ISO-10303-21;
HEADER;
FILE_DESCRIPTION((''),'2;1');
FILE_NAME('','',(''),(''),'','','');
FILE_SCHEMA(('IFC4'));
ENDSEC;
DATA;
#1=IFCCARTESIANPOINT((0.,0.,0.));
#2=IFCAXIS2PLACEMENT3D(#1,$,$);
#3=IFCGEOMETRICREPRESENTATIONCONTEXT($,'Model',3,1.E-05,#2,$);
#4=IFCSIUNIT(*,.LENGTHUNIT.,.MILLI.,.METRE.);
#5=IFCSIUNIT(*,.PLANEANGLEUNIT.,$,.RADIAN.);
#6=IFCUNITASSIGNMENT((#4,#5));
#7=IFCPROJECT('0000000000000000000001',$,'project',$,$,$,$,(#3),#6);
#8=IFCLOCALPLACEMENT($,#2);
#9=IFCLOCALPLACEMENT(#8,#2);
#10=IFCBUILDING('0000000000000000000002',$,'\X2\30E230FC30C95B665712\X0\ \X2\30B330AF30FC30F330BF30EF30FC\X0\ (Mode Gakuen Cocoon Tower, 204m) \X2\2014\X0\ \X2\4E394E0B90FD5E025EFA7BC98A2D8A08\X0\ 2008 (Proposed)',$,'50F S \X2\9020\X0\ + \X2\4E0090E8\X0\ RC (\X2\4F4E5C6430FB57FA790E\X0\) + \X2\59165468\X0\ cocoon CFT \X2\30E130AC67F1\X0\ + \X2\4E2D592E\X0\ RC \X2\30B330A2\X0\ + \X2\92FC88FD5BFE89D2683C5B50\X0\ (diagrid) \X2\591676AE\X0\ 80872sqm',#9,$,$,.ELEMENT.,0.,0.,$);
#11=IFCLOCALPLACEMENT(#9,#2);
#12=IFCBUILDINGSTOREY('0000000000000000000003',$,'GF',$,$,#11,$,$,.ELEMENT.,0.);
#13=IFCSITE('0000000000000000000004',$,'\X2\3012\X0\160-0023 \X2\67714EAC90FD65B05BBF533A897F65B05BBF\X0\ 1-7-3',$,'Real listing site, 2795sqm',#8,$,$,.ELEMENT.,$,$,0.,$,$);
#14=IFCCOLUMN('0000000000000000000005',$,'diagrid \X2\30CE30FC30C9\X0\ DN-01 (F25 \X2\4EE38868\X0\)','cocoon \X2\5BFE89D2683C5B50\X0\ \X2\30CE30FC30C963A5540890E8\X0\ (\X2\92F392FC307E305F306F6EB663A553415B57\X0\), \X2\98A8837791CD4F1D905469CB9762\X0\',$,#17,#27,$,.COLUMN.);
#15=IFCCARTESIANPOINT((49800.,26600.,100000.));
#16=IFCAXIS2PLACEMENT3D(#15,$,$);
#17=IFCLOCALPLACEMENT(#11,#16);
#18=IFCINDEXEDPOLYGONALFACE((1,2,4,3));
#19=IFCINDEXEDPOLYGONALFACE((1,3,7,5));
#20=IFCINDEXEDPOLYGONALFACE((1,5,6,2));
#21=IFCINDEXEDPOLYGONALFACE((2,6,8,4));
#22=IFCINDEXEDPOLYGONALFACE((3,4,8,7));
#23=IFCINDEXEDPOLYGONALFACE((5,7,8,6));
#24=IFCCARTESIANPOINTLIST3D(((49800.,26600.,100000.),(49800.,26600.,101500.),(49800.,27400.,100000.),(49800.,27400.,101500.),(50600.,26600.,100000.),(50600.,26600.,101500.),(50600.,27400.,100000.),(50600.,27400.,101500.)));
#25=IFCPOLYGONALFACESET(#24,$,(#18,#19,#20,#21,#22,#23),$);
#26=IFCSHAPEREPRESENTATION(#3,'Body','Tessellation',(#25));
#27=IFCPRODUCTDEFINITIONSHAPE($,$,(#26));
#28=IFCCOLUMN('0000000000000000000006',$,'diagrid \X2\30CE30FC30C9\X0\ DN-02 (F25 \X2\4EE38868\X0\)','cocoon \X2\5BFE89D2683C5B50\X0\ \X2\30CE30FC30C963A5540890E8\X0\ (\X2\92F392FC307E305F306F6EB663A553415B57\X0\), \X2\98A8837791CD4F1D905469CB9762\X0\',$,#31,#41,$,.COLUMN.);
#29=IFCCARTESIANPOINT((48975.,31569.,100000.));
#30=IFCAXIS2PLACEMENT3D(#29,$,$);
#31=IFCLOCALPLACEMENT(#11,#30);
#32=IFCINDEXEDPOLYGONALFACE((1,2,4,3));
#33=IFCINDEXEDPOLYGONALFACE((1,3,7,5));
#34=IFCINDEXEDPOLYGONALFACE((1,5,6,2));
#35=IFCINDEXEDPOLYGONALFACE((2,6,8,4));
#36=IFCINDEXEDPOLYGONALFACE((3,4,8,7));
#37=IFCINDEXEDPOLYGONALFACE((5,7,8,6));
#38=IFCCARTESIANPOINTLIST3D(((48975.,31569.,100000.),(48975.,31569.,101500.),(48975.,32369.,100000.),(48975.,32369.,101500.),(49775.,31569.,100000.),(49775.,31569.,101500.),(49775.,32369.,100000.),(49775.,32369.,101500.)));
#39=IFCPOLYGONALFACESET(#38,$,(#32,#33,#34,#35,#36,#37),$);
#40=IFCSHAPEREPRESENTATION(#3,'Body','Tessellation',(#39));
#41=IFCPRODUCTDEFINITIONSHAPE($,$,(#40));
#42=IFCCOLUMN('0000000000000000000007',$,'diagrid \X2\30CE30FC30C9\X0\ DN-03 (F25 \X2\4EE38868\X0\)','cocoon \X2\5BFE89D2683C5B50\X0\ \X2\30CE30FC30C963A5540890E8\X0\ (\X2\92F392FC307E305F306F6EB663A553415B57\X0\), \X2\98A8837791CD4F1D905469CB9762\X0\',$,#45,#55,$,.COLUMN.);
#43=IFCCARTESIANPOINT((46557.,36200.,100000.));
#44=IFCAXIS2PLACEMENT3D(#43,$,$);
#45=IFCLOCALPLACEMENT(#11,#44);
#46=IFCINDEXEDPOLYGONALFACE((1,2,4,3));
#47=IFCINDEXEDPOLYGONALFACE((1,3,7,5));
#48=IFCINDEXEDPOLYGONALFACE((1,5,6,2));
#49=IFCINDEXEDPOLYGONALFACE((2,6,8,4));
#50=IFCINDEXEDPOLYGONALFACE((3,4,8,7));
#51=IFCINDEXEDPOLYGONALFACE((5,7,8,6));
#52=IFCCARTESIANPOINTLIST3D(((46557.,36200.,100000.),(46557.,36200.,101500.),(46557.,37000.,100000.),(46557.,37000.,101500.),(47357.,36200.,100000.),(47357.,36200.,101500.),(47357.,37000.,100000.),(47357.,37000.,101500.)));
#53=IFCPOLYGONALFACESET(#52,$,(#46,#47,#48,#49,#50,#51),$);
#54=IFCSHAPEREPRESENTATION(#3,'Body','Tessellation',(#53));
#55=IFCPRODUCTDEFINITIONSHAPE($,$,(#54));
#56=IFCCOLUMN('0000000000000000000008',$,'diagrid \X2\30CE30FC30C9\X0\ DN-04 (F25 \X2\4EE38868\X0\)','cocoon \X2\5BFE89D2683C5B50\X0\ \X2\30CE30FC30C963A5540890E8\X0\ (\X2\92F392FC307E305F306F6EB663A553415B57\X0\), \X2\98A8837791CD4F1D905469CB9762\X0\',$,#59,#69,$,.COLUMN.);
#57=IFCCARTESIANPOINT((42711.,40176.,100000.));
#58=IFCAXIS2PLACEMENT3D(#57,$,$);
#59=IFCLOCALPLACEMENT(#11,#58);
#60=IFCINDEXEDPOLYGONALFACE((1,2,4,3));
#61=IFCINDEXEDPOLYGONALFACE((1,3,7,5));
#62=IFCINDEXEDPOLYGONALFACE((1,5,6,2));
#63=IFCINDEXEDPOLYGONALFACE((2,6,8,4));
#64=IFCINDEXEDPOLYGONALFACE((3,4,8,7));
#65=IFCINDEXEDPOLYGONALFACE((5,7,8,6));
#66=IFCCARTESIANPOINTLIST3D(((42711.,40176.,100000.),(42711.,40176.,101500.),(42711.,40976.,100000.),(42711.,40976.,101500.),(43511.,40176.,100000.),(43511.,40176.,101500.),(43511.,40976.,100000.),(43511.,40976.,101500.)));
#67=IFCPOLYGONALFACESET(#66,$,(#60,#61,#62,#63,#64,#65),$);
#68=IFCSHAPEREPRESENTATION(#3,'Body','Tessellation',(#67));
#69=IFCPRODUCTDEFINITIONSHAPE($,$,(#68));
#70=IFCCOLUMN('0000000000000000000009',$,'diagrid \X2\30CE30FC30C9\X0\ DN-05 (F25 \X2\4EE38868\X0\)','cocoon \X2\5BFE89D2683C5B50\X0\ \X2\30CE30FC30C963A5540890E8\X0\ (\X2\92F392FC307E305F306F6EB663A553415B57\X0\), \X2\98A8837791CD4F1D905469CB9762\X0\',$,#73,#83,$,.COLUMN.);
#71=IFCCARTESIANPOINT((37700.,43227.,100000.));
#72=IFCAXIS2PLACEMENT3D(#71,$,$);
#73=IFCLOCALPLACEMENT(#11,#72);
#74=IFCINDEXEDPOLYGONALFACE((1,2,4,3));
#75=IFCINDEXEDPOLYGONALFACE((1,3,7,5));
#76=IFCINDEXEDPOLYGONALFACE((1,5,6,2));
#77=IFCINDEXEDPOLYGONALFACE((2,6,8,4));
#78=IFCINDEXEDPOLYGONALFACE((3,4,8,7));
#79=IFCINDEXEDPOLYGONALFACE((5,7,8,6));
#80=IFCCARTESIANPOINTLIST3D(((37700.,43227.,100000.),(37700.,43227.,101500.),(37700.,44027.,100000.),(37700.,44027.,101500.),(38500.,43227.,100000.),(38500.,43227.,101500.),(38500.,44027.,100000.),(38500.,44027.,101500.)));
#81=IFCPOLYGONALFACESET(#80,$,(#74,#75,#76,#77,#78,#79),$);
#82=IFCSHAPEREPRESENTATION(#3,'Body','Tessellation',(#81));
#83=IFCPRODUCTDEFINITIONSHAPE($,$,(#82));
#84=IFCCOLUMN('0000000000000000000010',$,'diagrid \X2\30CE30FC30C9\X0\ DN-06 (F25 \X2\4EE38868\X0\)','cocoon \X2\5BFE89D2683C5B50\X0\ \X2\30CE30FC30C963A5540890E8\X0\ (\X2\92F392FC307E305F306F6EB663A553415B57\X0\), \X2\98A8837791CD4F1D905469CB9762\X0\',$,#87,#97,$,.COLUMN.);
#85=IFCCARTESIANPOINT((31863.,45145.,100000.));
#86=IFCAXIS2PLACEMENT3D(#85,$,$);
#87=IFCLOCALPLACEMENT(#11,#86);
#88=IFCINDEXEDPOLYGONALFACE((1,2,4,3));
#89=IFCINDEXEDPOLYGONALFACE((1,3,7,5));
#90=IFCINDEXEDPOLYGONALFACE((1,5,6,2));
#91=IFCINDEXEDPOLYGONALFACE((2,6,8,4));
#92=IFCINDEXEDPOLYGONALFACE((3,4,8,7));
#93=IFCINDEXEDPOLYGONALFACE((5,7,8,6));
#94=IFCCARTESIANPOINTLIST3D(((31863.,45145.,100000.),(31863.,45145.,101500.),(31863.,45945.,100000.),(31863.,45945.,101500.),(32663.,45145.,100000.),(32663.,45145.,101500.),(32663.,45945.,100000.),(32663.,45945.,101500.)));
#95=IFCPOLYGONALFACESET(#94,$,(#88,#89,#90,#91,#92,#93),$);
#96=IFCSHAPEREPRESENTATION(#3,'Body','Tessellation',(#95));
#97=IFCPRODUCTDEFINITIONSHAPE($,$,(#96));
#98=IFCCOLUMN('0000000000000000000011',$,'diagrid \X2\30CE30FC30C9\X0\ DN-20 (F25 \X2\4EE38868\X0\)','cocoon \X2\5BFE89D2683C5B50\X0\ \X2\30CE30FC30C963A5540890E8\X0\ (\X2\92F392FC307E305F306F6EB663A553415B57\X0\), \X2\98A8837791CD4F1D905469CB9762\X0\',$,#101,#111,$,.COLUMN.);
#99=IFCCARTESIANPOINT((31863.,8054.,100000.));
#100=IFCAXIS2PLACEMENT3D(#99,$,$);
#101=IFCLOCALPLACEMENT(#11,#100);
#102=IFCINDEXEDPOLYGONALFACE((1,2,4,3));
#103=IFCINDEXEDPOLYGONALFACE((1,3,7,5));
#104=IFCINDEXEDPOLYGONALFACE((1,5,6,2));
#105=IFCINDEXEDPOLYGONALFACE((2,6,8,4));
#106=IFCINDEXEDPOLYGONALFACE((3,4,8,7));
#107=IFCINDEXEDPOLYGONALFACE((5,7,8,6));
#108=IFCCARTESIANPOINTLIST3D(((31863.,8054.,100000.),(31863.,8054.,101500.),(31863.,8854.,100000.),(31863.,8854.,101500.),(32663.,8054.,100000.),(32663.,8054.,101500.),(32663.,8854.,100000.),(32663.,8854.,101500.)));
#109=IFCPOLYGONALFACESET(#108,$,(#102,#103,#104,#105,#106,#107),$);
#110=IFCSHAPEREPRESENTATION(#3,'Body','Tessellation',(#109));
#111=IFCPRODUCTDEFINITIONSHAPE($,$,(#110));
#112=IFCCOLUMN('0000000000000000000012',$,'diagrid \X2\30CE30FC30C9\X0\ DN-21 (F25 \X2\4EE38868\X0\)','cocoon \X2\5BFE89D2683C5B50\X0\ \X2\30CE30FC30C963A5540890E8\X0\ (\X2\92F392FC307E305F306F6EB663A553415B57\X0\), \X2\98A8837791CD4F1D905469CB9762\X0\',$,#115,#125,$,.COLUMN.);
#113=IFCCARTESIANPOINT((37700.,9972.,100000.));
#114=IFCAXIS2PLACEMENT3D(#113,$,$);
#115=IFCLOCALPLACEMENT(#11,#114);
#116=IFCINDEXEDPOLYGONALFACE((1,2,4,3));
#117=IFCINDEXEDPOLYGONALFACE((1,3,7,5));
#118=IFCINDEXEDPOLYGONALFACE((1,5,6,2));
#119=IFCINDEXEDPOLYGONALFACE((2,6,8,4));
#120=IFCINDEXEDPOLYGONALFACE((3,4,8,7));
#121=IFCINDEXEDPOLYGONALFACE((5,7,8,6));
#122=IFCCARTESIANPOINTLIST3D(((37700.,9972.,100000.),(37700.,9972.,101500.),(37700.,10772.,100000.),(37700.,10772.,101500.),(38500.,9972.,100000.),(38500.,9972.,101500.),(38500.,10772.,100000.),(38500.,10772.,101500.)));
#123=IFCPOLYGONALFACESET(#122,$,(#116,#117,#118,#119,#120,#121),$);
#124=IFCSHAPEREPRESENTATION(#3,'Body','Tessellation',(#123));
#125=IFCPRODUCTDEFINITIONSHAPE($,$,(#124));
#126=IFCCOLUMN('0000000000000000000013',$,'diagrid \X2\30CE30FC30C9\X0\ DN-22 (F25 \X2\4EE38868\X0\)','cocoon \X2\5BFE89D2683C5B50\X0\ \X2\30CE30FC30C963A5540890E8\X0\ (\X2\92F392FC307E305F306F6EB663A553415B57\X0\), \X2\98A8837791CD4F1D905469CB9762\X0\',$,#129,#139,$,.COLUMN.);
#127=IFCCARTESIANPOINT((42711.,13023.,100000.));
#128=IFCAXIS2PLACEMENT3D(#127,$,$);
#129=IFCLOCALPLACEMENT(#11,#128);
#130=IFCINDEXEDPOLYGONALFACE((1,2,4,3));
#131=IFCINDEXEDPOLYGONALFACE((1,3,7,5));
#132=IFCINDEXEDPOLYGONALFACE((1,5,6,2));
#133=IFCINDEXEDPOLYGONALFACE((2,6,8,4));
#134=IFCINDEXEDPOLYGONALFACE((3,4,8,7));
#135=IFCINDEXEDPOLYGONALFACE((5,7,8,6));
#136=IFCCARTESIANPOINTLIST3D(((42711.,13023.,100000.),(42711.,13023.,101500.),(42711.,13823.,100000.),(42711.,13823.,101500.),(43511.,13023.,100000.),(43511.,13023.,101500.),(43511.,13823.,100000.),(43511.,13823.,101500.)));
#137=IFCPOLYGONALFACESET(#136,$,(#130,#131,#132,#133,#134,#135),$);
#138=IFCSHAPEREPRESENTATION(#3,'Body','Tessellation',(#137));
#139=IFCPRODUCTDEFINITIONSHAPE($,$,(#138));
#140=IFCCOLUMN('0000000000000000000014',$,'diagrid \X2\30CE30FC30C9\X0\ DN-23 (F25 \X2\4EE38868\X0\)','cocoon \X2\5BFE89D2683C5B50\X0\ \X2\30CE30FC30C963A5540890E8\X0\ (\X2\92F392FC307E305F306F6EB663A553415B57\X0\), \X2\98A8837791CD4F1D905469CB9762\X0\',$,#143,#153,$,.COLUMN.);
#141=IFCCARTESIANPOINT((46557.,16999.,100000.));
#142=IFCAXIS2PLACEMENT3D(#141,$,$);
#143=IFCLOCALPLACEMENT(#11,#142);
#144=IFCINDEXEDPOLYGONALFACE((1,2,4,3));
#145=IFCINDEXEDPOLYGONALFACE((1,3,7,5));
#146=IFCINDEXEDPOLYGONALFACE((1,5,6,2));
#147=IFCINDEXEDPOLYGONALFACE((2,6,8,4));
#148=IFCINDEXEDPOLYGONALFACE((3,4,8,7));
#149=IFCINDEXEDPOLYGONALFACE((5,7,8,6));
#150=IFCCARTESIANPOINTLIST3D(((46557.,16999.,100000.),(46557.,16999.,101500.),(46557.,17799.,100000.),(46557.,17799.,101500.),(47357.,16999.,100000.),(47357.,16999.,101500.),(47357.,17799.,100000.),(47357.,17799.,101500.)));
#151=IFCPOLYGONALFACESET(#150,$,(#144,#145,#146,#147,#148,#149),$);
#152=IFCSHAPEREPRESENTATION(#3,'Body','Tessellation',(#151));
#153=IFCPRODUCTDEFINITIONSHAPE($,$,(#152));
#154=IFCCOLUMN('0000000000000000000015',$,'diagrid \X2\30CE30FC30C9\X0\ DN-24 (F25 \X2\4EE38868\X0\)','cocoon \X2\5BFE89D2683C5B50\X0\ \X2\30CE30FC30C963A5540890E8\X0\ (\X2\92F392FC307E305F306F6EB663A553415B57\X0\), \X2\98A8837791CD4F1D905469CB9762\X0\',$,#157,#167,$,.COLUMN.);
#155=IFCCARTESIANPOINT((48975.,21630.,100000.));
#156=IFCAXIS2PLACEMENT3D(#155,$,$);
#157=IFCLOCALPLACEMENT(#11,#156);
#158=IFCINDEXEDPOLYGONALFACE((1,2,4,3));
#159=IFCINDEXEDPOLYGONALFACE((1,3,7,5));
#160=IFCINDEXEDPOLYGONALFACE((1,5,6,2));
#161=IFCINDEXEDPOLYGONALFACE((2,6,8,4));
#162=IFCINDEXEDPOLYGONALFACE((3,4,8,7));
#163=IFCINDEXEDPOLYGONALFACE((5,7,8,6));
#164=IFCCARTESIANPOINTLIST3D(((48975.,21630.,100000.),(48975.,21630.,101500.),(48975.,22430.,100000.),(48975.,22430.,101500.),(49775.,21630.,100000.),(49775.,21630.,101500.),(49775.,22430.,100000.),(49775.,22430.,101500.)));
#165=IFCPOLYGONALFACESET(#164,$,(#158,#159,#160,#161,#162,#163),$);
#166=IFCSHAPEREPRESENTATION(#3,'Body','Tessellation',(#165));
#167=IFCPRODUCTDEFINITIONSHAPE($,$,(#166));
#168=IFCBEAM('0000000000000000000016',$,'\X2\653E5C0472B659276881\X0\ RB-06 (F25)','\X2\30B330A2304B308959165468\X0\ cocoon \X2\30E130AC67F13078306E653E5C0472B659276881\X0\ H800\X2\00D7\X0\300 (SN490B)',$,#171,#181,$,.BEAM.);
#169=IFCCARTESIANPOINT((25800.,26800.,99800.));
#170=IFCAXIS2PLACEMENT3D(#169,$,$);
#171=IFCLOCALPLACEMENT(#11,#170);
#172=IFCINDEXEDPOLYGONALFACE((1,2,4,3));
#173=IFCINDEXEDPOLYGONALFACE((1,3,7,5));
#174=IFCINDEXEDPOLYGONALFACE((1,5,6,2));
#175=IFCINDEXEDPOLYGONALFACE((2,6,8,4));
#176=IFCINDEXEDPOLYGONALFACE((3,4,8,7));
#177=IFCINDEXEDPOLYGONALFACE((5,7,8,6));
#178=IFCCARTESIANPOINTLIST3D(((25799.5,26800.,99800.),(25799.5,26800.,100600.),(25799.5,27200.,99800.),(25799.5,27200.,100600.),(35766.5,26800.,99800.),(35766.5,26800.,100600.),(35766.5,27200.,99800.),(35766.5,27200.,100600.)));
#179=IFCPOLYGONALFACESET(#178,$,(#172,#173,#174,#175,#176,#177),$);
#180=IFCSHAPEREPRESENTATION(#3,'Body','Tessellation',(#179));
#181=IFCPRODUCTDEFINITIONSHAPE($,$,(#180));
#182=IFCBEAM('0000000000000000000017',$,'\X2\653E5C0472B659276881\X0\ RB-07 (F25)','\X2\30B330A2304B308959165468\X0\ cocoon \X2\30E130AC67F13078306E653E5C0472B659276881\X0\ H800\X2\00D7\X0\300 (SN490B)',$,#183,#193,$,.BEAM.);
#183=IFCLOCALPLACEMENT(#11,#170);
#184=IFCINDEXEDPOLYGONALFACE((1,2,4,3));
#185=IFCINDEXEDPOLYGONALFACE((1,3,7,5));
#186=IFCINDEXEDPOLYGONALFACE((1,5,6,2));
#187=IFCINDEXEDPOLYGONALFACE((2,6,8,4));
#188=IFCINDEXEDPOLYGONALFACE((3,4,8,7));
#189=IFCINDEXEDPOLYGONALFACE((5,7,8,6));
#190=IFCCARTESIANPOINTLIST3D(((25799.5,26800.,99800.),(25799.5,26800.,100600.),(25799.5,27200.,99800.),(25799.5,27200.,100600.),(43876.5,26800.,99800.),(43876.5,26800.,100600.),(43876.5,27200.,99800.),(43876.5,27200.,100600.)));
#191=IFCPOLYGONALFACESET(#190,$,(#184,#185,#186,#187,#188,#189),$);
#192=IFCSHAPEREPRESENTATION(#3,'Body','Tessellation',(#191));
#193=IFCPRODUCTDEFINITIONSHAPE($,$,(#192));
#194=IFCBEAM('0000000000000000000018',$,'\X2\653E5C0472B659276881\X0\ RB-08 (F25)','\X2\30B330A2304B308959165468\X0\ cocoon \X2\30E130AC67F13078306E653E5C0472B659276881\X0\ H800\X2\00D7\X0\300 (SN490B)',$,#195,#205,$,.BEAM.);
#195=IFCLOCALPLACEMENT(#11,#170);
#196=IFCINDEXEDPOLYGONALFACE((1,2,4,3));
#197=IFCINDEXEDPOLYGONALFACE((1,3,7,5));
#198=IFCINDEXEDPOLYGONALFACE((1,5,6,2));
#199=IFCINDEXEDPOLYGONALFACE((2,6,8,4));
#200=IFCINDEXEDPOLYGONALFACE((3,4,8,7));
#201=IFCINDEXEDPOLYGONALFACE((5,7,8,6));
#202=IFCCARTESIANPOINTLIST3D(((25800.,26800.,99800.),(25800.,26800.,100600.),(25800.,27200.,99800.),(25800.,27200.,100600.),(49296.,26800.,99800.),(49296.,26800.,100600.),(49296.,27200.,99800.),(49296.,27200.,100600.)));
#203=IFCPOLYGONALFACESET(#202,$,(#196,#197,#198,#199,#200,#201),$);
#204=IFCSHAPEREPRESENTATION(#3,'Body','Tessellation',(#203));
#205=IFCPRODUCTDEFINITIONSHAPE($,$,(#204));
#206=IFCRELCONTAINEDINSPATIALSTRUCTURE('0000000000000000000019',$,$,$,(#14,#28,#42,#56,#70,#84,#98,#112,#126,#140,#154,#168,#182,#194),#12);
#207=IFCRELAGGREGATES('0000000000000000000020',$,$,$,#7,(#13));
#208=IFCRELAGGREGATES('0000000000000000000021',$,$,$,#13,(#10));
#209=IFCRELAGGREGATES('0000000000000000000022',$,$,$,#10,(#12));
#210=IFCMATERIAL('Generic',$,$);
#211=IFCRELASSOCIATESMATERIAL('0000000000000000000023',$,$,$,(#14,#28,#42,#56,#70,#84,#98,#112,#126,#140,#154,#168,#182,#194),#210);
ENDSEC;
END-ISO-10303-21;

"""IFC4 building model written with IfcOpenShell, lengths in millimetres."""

from ifc_helpers import new_model, si_unit, frame, frame_2d, origin, place, context, project, spatial, rectangle, extrude, material, element, save


model = new_model("IFC4")

# Units and contexts
model_context = context("Model", 3, precision=1e-05, world=origin())
ifc_project = project(units=[si_unit("LENGTHUNIT", "METRE", prefix="MILLI"), si_unit("PLANEANGLEUNIT", "RADIAN")], contexts=[model_context])

# Site, building, storey
site_placement = place(None, origin())
site = spatial("IfcSite", under=ifc_project, at=site_placement, Name="〒160-0023 東京都新宿区西新宿 1-7-3", ObjectType="Real listing site, 2795sqm", CompositionType="ELEMENT", RefElevation=0.0)
building_placement = place(site_placement, origin())
building = spatial("IfcBuilding", under=site, at=building_placement, Name="モード学園 コクーンタワー (Mode Gakuen Cocoon Tower, 204m) — 丹下都市建築設計 2008 (Proposed)", ObjectType="50F S 造 + 一部 RC (低層・基礎) + 外周 cocoon CFT メガ柱 + 中央 RC コア + 鋼製対角格子 (diagrid) 外皮 80872sqm", CompositionType="ELEMENT", ElevationOfRefHeight=0.0, ElevationOfTerrain=0.0)
storey_placement = place(building_placement, origin())
storey = spatial("IfcBuildingStorey", under=building, at=storey_placement, Name="GF", CompositionType="ELEMENT", Elevation=0.0)

# Columns
ifc_material_1 = material(Name="Generic")
column_1_placement = place(storey_placement, frame((49800.0, 26600.0, 100000.0)))
element("IfcColumn", 1, at=column_1_placement, inside=storey, material=ifc_material_1, Name="diagrid ノード DN-01 (F25 代表)", Description="cocoon 対角格子 ノード接合部 (鋳鋼または溶接十字), 風荷重伝達構面", PredefinedType="COLUMN", context=model_context, shape_type="SweptSolid", body=[
    extrude(rectangle(XDim=800.0, YDim=800.0, at=frame_2d((400.0, 400.0))), frame((49800.0, 26600.0, 100000.0)), (0.0, 0.0, 1.0), 1500.0),
])
column_2_placement = place(storey_placement, frame((48975.0, 31569.0, 100000.0)))
element("IfcColumn", 2, at=column_2_placement, inside=storey, material=ifc_material_1, Name="diagrid ノード DN-02 (F25 代表)", Description="cocoon 対角格子 ノード接合部 (鋳鋼または溶接十字), 風荷重伝達構面", PredefinedType="COLUMN", context=model_context, shape_type="SweptSolid", body=[
    extrude(rectangle(XDim=800.0, YDim=800.0, at=frame_2d((400.0, 400.0))), frame((48975.0, 31569.0, 100000.0)), (0.0, 0.0, 1.0), 1500.0),
])
column_3_placement = place(storey_placement, frame((46557.0, 36200.0, 100000.0)))
element("IfcColumn", 3, at=column_3_placement, inside=storey, material=ifc_material_1, Name="diagrid ノード DN-03 (F25 代表)", Description="cocoon 対角格子 ノード接合部 (鋳鋼または溶接十字), 風荷重伝達構面", PredefinedType="COLUMN", context=model_context, shape_type="SweptSolid", body=[
    extrude(rectangle(XDim=800.0, YDim=800.0, at=frame_2d((400.0, 400.0))), frame((46557.0, 36200.0, 100000.0)), (0.0, 0.0, 1.0), 1500.0),
])
column_4_placement = place(storey_placement, frame((42711.0, 40176.0, 100000.0)))
element("IfcColumn", 4, at=column_4_placement, inside=storey, material=ifc_material_1, Name="diagrid ノード DN-04 (F25 代表)", Description="cocoon 対角格子 ノード接合部 (鋳鋼または溶接十字), 風荷重伝達構面", PredefinedType="COLUMN", context=model_context, shape_type="SweptSolid", body=[
    extrude(rectangle(XDim=800.0, YDim=800.0, at=frame_2d((400.0, 400.0))), frame((42711.0, 40176.0, 100000.0)), (0.0, 0.0, 1.0), 1500.0),
])
column_5_placement = place(storey_placement, frame((37700.0, 43227.0, 100000.0)))
element("IfcColumn", 5, at=column_5_placement, inside=storey, material=ifc_material_1, Name="diagrid ノード DN-05 (F25 代表)", Description="cocoon 対角格子 ノード接合部 (鋳鋼または溶接十字), 風荷重伝達構面", PredefinedType="COLUMN", context=model_context, shape_type="SweptSolid", body=[
    extrude(rectangle(XDim=800.0, YDim=800.0, at=frame_2d((400.0, 400.0))), frame((37700.0, 43227.0, 100000.0)), (0.0, 0.0, 1.0), 1500.0),
])
column_6_placement = place(storey_placement, frame((31863.0, 45145.0, 100000.0)))
element("IfcColumn", 6, at=column_6_placement, inside=storey, material=ifc_material_1, Name="diagrid ノード DN-06 (F25 代表)", Description="cocoon 対角格子 ノード接合部 (鋳鋼または溶接十字), 風荷重伝達構面", PredefinedType="COLUMN", context=model_context, shape_type="SweptSolid", body=[
    extrude(rectangle(XDim=800.0, YDim=800.0, at=frame_2d((400.0, 400.0))), frame((31863.0, 45145.0, 100000.0)), (0.0, 0.0, 1.0), 1500.0),
])
column_7_placement = place(storey_placement, frame((31863.0, 8054.0, 100000.0)))
element("IfcColumn", 7, at=column_7_placement, inside=storey, material=ifc_material_1, Name="diagrid ノード DN-20 (F25 代表)", Description="cocoon 対角格子 ノード接合部 (鋳鋼または溶接十字), 風荷重伝達構面", PredefinedType="COLUMN", context=model_context, shape_type="SweptSolid", body=[
    extrude(rectangle(XDim=800.0, YDim=800.0, at=frame_2d((400.0, 400.0))), frame((31863.0, 8054.0, 100000.0)), (0.0, 0.0, 1.0), 1500.0),
])
column_8_placement = place(storey_placement, frame((37700.0, 9972.0, 100000.0)))
element("IfcColumn", 8, at=column_8_placement, inside=storey, material=ifc_material_1, Name="diagrid ノード DN-21 (F25 代表)", Description="cocoon 対角格子 ノード接合部 (鋳鋼または溶接十字), 風荷重伝達構面", PredefinedType="COLUMN", context=model_context, shape_type="SweptSolid", body=[
    extrude(rectangle(XDim=800.0, YDim=800.0, at=frame_2d((400.0, 400.0))), frame((37700.0, 9972.0, 100000.0)), (0.0, 0.0, 1.0), 1500.0),
])
column_9_placement = place(storey_placement, frame((42711.0, 13023.0, 100000.0)))
element("IfcColumn", 9, at=column_9_placement, inside=storey, material=ifc_material_1, Name="diagrid ノード DN-22 (F25 代表)", Description="cocoon 対角格子 ノード接合部 (鋳鋼または溶接十字), 風荷重伝達構面", PredefinedType="COLUMN", context=model_context, shape_type="SweptSolid", body=[
    extrude(rectangle(XDim=800.0, YDim=800.0, at=frame_2d((400.0, 400.0))), frame((42711.0, 13023.0, 100000.0)), (0.0, 0.0, 1.0), 1500.0),
])
column_10_placement = place(storey_placement, frame((46557.0, 16999.0, 100000.0)))
element("IfcColumn", 10, at=column_10_placement, inside=storey, material=ifc_material_1, Name="diagrid ノード DN-23 (F25 代表)", Description="cocoon 対角格子 ノード接合部 (鋳鋼または溶接十字), 風荷重伝達構面", PredefinedType="COLUMN", context=model_context, shape_type="SweptSolid", body=[
    extrude(rectangle(XDim=800.0, YDim=800.0, at=frame_2d((400.0, 400.0))), frame((46557.0, 16999.0, 100000.0)), (0.0, 0.0, 1.0), 1500.0),
])
column_11_placement = place(storey_placement, frame((48975.0, 21630.0, 100000.0)))
element("IfcColumn", 11, at=column_11_placement, inside=storey, material=ifc_material_1, Name="diagrid ノード DN-24 (F25 代表)", Description="cocoon 対角格子 ノード接合部 (鋳鋼または溶接十字), 風荷重伝達構面", PredefinedType="COLUMN", context=model_context, shape_type="SweptSolid", body=[
    extrude(rectangle(XDim=800.0, YDim=800.0, at=frame_2d((400.0, 400.0))), frame((48975.0, 21630.0, 100000.0)), (0.0, 0.0, 1.0), 1500.0),
])

# Beams
beam_1_placement = place(storey_placement, frame((25800.0, 26800.0, 99800.0)))
element("IfcBeam", 12, at=beam_1_placement, inside=storey, material=ifc_material_1, Name="放射状大梁 RB-06 (F25)", Description="コアから外周 cocoon メガ柱への放射状大梁 H800×300 (SN490B)", PredefinedType="BEAM", context=model_context, shape_type="SweptSolid", body=[
    extrude(rectangle(XDim=9967.0, YDim=400.0, at=frame_2d((4983.0, 200.0))), frame((25800.0, 26800.0, 99800.0)), (0.0, 0.0, 1.0), 800.0),
])
beam_2_placement = place(storey_placement, frame((25800.0, 26800.0, 99800.0)))
element("IfcBeam", 13, at=beam_2_placement, inside=storey, material=ifc_material_1, Name="放射状大梁 RB-07 (F25)", Description="コアから外周 cocoon メガ柱への放射状大梁 H800×300 (SN490B)", PredefinedType="BEAM", context=model_context, shape_type="SweptSolid", body=[
    extrude(rectangle(XDim=18077.0, YDim=400.0, at=frame_2d((9038.0, 200.0))), frame((25800.0, 26800.0, 99800.0)), (0.0, 0.0, 1.0), 800.0),
])
beam_3_placement = place(storey_placement, frame((25800.0, 26800.0, 99800.0)))
element("IfcBeam", 14, at=beam_3_placement, inside=storey, material=ifc_material_1, Name="放射状大梁 RB-08 (F25)", Description="コアから外周 cocoon メガ柱への放射状大梁 H800×300 (SN490B)", PredefinedType="BEAM", context=model_context, shape_type="SweptSolid", body=[
    extrude(rectangle(XDim=23496.0, YDim=400.0, at=frame_2d((11748.0, 200.0))), frame((25800.0, 26800.0, 99800.0)), (0.0, 0.0, 1.0), 800.0),
])

save(model, "model.ifc")
